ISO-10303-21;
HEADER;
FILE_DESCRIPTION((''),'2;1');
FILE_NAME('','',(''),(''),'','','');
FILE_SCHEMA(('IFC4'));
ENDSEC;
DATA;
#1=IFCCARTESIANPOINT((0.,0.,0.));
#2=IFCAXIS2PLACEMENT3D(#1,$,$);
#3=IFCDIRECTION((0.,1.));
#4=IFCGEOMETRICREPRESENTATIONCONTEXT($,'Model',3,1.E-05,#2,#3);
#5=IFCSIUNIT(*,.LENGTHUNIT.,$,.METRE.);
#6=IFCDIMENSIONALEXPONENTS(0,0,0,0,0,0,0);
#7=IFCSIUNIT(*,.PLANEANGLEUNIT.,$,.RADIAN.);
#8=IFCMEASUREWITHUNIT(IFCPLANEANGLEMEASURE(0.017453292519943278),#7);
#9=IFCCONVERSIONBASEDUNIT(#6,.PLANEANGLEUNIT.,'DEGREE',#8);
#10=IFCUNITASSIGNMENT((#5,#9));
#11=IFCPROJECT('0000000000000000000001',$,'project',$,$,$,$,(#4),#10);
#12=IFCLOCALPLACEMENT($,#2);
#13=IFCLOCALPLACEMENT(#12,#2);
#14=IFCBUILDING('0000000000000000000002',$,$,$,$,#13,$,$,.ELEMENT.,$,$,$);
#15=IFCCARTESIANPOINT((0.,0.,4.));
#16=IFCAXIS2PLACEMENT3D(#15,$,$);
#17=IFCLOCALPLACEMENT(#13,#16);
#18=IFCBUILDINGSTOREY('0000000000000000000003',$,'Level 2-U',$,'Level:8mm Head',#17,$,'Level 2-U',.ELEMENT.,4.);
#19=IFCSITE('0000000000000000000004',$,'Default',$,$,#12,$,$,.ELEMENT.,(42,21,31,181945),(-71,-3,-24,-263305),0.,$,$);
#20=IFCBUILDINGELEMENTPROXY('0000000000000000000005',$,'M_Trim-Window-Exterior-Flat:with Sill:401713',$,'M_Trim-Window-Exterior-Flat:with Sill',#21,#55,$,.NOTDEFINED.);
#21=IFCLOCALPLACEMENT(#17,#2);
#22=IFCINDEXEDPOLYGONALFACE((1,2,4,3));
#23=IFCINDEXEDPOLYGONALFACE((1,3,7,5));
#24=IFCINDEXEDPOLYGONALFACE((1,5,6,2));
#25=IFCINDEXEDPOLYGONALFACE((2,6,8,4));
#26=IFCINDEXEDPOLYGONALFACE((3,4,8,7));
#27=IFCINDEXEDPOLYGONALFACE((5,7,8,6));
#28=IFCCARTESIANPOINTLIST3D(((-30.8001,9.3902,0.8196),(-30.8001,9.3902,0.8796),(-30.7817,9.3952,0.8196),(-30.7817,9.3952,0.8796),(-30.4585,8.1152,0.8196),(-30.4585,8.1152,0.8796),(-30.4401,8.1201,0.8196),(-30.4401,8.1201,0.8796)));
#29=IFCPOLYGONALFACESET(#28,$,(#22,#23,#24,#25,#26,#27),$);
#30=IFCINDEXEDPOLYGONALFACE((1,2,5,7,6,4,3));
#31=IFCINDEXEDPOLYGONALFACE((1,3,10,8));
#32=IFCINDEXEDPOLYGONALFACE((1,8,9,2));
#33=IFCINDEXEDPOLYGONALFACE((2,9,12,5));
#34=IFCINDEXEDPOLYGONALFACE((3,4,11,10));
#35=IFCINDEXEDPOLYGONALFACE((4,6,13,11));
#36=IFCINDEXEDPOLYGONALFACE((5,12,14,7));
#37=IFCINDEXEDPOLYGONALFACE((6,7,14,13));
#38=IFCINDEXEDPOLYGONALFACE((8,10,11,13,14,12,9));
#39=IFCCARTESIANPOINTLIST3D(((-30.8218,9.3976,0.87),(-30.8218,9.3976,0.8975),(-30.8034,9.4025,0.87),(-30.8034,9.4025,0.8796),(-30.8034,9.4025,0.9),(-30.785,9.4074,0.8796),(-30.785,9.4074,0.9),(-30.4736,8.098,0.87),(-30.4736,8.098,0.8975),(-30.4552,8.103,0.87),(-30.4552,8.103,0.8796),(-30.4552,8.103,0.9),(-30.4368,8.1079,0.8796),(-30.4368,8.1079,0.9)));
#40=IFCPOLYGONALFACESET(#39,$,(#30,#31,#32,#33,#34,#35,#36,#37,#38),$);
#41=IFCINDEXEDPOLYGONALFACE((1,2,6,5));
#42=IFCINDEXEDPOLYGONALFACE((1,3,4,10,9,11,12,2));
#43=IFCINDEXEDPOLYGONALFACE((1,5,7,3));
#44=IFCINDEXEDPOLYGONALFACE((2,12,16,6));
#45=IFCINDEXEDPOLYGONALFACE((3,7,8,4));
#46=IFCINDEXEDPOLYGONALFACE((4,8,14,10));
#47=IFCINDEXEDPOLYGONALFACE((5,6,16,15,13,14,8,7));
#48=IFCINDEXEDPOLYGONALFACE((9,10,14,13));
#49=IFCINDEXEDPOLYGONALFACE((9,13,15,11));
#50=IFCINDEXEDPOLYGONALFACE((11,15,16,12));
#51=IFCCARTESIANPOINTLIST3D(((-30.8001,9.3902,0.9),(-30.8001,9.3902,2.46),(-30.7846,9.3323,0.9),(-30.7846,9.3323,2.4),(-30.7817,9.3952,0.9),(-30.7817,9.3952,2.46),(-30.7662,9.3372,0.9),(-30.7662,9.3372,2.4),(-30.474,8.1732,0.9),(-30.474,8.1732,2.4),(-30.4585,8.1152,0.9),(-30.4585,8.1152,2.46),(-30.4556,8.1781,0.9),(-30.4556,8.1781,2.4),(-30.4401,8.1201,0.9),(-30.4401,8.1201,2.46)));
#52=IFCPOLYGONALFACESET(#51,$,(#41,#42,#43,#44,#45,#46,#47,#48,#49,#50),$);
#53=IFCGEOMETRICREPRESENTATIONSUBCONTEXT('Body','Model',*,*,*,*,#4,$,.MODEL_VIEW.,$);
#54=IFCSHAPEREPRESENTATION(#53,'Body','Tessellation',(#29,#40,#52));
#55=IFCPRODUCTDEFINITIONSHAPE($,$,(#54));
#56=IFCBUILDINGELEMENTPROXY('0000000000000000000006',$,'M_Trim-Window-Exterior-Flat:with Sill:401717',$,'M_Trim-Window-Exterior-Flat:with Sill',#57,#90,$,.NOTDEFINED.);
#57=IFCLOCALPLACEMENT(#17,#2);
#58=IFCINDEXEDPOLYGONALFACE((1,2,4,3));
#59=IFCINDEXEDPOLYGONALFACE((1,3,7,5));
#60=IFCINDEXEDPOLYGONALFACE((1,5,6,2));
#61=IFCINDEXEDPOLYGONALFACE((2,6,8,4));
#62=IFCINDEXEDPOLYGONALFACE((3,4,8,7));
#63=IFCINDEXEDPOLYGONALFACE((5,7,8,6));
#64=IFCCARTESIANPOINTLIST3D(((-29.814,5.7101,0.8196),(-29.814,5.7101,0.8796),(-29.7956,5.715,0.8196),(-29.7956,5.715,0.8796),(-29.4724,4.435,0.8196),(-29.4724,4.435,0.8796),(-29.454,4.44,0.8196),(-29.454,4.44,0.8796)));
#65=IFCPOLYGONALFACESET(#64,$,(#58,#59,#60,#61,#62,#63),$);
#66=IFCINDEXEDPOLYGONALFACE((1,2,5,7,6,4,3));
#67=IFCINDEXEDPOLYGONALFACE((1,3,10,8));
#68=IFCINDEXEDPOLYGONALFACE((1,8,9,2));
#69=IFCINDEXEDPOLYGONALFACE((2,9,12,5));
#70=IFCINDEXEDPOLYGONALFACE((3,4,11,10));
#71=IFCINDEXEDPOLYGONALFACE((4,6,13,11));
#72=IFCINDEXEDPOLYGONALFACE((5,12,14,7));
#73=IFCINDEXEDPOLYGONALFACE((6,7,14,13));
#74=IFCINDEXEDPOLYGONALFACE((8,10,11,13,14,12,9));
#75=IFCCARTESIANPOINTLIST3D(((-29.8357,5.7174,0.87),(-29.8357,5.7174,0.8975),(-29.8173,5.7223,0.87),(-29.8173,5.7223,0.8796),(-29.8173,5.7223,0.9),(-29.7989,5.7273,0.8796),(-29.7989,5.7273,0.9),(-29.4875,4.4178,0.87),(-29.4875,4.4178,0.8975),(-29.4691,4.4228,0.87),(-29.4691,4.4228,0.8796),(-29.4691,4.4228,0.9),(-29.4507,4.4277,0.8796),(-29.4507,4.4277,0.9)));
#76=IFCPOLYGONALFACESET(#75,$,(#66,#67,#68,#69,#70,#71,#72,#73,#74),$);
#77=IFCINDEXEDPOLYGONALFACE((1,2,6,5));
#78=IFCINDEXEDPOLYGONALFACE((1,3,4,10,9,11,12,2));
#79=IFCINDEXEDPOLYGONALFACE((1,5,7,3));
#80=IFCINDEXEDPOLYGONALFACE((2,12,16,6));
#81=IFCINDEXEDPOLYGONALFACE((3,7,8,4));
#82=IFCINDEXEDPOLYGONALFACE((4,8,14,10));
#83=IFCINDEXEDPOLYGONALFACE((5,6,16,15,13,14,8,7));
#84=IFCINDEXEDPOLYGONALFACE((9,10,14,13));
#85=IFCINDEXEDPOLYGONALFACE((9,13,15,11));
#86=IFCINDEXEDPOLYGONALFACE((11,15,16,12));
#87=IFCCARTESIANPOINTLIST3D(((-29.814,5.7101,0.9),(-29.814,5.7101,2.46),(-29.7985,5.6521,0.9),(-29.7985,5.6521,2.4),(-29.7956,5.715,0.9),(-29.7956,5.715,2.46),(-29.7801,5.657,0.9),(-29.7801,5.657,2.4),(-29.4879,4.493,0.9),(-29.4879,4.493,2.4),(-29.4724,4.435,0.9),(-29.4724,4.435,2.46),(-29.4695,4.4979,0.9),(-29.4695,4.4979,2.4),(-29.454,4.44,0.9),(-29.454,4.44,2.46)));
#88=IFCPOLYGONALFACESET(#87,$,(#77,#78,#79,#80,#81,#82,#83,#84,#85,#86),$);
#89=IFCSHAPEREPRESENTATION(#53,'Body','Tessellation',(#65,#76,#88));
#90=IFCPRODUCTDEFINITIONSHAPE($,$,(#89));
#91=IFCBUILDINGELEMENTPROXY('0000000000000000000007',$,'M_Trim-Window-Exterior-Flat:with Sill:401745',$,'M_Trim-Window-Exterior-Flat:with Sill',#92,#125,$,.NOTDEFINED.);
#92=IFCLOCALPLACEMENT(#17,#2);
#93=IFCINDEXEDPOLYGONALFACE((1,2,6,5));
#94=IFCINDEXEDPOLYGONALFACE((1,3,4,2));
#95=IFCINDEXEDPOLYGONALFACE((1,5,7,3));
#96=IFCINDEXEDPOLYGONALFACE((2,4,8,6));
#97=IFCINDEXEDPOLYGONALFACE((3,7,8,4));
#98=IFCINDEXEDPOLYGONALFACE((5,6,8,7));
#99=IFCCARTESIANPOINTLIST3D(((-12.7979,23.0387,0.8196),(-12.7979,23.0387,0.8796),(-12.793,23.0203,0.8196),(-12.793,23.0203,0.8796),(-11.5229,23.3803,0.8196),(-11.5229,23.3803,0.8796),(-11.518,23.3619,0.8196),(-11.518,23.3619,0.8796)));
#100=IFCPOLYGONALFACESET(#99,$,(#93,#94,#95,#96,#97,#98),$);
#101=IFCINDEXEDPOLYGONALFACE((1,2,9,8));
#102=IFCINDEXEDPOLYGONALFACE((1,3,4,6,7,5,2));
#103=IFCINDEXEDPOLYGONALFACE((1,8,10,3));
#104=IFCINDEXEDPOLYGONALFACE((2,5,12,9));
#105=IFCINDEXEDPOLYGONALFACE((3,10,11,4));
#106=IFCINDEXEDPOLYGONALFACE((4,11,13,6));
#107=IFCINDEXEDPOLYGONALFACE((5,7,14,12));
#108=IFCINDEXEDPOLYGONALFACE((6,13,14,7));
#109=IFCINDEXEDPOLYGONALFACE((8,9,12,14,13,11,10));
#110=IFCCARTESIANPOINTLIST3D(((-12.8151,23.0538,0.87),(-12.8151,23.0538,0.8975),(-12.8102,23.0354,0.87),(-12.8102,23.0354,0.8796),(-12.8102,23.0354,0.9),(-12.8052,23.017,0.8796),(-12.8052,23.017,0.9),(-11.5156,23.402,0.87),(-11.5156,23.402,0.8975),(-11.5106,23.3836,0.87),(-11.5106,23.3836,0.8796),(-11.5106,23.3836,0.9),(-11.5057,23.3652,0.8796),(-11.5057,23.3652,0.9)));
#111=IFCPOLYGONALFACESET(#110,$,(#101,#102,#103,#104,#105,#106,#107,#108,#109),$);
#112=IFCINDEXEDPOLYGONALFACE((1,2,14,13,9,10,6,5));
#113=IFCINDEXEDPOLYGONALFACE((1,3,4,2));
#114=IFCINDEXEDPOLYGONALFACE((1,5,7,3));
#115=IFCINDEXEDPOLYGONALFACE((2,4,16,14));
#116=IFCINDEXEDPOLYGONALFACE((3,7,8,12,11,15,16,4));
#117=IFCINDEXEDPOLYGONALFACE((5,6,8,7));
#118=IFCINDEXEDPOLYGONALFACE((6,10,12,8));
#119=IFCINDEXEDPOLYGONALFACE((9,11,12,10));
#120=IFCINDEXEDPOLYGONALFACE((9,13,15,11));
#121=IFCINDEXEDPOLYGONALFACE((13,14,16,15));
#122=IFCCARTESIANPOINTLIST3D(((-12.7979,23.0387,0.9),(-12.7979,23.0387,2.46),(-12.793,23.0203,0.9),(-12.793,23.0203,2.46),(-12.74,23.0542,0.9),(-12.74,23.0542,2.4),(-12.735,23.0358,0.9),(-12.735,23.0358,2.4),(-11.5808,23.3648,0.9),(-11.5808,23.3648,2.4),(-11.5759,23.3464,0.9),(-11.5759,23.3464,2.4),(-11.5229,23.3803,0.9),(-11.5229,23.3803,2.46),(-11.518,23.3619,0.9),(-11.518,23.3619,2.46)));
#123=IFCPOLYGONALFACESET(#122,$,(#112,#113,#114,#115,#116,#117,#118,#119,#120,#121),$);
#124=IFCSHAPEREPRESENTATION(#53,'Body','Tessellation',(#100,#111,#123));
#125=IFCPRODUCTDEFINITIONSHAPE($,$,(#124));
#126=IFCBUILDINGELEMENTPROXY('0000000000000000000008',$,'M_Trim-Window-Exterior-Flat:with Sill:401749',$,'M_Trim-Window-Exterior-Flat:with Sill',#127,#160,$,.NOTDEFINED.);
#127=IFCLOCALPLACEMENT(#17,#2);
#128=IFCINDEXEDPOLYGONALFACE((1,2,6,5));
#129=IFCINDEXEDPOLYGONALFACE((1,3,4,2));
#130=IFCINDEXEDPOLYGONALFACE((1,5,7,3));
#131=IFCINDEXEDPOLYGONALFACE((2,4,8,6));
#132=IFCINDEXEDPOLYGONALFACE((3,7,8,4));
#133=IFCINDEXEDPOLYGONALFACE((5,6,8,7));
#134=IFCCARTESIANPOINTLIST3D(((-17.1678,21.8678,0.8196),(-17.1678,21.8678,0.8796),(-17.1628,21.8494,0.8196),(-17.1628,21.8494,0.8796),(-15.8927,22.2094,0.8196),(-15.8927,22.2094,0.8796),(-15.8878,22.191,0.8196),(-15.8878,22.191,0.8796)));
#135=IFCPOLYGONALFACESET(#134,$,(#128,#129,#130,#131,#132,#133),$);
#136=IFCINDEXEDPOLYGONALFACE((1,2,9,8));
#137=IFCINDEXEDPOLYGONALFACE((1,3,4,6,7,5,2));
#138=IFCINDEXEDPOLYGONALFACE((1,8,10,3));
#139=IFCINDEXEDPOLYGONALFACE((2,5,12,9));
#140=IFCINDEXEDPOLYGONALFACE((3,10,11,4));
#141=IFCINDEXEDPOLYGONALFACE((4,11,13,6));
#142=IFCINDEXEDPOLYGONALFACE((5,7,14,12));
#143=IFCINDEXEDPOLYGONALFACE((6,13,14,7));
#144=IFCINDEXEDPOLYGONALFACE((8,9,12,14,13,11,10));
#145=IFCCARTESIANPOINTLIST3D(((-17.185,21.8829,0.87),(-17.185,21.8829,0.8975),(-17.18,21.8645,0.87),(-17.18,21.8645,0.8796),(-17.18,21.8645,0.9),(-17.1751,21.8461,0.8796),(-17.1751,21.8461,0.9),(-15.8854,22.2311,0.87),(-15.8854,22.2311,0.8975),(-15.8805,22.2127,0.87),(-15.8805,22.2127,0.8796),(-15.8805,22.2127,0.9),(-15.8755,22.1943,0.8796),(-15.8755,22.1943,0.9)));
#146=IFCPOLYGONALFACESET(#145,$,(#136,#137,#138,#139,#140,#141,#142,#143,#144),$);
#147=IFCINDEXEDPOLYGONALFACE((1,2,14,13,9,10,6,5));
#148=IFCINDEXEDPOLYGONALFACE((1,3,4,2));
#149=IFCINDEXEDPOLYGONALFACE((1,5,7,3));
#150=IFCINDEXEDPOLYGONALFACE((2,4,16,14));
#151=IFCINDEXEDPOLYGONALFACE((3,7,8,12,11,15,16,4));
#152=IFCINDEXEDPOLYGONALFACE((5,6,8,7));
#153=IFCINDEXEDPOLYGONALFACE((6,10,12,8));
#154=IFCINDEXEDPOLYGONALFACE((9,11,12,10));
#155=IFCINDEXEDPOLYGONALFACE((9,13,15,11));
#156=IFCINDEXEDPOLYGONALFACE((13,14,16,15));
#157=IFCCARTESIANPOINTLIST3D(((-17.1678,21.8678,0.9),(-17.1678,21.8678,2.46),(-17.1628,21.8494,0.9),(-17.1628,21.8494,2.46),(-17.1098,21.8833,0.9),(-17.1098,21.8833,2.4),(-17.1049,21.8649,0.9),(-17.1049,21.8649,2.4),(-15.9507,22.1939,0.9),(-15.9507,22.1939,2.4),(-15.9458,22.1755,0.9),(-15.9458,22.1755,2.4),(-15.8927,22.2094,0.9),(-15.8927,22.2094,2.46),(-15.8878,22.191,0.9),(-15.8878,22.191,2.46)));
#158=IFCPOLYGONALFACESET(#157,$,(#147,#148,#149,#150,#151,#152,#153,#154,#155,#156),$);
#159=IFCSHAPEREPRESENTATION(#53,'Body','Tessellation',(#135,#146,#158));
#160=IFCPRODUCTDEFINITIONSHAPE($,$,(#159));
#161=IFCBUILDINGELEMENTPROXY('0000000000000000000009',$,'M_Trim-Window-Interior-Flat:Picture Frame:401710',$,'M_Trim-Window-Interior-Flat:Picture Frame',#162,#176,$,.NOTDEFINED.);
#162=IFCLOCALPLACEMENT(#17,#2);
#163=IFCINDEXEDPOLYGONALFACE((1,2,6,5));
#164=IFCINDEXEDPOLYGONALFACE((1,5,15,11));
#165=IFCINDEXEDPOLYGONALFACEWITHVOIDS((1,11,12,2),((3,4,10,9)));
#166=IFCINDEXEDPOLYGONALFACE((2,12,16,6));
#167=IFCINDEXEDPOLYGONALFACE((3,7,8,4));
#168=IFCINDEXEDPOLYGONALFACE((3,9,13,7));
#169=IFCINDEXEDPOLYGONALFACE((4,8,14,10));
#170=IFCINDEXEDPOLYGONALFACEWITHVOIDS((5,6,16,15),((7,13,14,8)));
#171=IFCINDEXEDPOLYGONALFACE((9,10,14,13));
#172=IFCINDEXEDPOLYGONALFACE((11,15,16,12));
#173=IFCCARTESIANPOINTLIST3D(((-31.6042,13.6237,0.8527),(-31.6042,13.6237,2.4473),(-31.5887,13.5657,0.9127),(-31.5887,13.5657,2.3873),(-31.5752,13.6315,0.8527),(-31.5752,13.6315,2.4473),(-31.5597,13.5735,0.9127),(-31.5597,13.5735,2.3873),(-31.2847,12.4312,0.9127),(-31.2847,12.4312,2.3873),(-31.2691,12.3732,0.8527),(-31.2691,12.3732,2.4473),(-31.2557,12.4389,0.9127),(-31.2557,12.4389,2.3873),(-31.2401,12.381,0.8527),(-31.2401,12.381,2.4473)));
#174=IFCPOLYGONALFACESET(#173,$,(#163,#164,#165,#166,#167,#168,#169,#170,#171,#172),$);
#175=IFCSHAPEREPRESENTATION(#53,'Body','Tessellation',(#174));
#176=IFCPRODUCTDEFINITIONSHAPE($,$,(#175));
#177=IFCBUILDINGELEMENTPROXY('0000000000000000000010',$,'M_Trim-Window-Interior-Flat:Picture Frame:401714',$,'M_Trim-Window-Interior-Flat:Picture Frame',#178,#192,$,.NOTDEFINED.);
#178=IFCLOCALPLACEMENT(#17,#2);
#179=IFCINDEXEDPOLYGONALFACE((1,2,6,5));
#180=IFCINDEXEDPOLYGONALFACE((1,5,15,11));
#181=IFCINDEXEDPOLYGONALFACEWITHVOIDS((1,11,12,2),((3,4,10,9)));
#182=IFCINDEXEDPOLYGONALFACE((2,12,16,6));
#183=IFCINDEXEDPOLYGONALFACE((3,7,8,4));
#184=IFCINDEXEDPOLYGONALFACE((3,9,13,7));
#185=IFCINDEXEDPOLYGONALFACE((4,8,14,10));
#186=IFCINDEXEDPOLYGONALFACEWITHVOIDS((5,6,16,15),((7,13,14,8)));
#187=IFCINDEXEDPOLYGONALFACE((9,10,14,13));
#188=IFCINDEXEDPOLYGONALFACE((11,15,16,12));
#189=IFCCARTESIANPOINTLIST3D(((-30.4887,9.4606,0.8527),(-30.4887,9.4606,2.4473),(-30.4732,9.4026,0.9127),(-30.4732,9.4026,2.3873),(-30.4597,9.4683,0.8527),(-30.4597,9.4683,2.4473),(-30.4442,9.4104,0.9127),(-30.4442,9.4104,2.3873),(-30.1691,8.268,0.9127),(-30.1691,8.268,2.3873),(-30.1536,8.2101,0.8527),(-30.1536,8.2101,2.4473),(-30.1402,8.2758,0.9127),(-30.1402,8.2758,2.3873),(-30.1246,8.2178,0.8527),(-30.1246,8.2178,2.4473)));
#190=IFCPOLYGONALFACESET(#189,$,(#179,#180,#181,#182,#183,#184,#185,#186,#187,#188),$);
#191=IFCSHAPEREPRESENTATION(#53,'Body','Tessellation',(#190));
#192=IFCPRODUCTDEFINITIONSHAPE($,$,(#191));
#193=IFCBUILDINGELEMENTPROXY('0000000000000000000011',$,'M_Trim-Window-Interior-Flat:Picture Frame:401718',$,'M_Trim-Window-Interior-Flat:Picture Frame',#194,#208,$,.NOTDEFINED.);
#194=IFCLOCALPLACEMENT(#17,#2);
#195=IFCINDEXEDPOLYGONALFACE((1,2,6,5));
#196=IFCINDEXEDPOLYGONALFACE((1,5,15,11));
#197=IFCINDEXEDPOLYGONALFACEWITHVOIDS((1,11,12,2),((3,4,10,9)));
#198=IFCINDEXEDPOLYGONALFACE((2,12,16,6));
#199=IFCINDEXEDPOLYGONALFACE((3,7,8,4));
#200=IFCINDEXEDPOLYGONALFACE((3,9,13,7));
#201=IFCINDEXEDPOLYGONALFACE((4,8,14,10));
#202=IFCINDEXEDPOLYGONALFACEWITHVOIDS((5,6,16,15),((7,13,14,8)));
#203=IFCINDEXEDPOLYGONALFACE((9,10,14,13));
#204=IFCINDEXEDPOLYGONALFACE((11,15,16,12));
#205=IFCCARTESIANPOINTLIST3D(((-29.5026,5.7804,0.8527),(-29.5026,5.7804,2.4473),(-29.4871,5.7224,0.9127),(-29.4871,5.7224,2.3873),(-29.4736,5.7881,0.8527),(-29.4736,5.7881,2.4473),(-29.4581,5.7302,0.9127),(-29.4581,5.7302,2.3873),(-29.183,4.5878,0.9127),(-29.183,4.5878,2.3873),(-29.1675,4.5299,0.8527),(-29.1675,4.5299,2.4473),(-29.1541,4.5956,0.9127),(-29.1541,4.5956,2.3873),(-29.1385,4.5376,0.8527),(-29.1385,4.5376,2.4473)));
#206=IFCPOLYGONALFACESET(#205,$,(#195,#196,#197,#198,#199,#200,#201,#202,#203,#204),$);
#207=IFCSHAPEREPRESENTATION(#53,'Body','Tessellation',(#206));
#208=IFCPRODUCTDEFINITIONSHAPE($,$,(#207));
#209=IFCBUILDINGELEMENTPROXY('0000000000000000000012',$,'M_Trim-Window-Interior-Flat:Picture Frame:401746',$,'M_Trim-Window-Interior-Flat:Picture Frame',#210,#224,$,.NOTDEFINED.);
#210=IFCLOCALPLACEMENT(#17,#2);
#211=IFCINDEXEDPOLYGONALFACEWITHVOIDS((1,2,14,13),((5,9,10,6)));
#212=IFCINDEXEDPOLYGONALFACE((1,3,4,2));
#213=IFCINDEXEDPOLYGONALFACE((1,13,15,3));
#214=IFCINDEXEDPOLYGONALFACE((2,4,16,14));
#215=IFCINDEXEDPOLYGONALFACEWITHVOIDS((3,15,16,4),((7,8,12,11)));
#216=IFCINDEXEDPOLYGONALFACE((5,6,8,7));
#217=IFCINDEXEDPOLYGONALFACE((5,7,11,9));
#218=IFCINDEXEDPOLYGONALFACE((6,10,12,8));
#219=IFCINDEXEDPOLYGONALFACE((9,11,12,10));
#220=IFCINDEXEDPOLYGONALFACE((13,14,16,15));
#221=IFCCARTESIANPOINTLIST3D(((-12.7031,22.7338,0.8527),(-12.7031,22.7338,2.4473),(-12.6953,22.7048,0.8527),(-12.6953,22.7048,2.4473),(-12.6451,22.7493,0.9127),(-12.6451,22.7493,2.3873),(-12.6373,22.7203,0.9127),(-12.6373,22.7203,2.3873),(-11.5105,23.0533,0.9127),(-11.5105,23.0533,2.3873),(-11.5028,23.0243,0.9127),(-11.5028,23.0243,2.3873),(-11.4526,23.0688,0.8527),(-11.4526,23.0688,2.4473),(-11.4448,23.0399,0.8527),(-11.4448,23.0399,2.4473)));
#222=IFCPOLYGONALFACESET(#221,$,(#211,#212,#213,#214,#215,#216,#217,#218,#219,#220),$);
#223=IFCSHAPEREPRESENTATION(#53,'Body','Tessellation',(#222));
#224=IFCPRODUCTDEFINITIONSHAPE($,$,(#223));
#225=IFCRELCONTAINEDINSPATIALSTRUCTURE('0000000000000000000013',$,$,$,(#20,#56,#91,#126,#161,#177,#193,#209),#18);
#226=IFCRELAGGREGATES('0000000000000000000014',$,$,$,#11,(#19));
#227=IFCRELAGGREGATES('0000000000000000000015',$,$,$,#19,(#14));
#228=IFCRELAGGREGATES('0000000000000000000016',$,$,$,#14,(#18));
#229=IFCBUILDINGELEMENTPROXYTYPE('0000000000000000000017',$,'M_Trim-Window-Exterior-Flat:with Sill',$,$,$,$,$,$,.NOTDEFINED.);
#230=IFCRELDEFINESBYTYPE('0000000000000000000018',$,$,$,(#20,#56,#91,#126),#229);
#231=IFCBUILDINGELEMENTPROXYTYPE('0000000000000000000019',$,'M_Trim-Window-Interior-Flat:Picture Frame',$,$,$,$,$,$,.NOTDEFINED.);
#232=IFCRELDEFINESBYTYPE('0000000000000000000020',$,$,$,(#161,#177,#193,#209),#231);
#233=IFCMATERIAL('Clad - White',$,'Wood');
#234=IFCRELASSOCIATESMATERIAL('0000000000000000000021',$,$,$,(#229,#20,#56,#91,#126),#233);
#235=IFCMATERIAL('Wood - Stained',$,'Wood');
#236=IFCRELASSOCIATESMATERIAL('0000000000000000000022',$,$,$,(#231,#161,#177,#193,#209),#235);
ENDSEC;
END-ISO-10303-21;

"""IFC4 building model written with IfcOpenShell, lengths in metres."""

from ifc_helpers import new_model, entity, si_unit, converted_unit, direction, frame, frame_2d, origin, place, context, subcontext, project, spatial, polyline, rectangle, outline, extrude, source, transform, mapped, material, type_object, type_shapes, element, save


model = new_model("IFC4")

# Units and contexts
model_context = context("Model", 3, precision=1e-05, world=origin(), true_north=direction((0.0, 1.0)))
body_context = subcontext(model_context, "Body", "Model", "MODEL_VIEW")
ifc_project = project(units=[si_unit("LENGTHUNIT", "METRE"), converted_unit("PLANEANGLEUNIT", "DEGREE", entity("IfcPlaneAngleMeasure", 0.017453292519943278), si_unit("PLANEANGLEUNIT", "RADIAN"), dimensions=[0, 0, 0, 0, 0, 0, 0])], contexts=[model_context])

# Site, building, storey
site_placement = place(None, origin())
site = spatial("IfcSite", under=ifc_project, at=site_placement, Name="Default", CompositionType="ELEMENT", RefLatitude=(42, 21, 31, 181945), RefLongitude=(-71, -3, -24, -263305), RefElevation=0.0)
building_placement = place(site_placement, origin())
building = spatial("IfcBuilding", under=site, at=building_placement, CompositionType="ELEMENT")
storey_placement = place(building_placement, frame((0.0, 0.0, 4.0)))
storey = spatial("IfcBuildingStorey", under=building, at=storey_placement, Name="Level 2-U", ObjectType="Level:8mm Head", LongName="Level 2-U", CompositionType="ELEMENT", Elevation=4.0)

# Building element proxies
ifc_material_1 = material(Name="Clad - White", Category="Wood")
ifc_material_2 = material(Name="Wood - Stained", Category="Wood")
building_element_proxy_type_1 = type_object("IfcBuildingElementProxyType", Name="M_Trim-Window-Exterior-Flat:with Sill", PredefinedType="NOTDEFINED", material=ifc_material_1)
shared_shape_1 = source(origin(), body_context, "Body", "SweptSolid", [
    extrude(rectangle(XDim=1.32, YDim=0.06, at=frame_2d((0.0, 0.0), x_axis=(1.0, 0.0))), frame((0.0, -1.5504, 0.0), z_axis=(0.0, 0.0, 1.0), x_axis=(-1.0, 0.0, 0.0)), (0.0, 0.0, 1.0), 0.019),
    extrude(outline(polyline([(-0.019, -0.0152), (0.0, -0.0152), (0.0, -0.0057), (0.019, -0.0057), (0.019, 0.0148), (0.0, 0.0148), (-0.019, 0.0123), (-0.019, -0.0152)])), frame((-0.6727, -1.5148, 0.019), z_axis=(1.0, 0.0, 0.0), x_axis=(0.0, 0.0, -1.0)), (0.0, 0.0, 1.0), 1.3454),
    extrude(outline(polyline([(-0.795, -0.66), (0.765, -0.66), (0.765, -0.6), (-0.735, -0.6), (-0.735, 0.6), (0.765, 0.6), (0.765, 0.66), (-0.795, 0.66), (-0.795, -0.66)])), frame((0.0, -0.735, 0.0), z_axis=(0.0, 0.0, 1.0), x_axis=(0.0, -1.0, 0.0)), (0.0, 0.0, 1.0), 0.019),
])
type_shapes(building_element_proxy_type_1, [shared_shape_1])
for number, where, z_axis, x_axis, name in (
    (1, (-30.6109, 8.7577, 2.4), (-0.965926, -0.258819, 0.0), (0.258819, -0.965926, 0.0), "M_Trim-Window-Exterior-Flat:with Sill:401713"),
    (2, (-29.6248, 5.0775, 2.4), (-0.965926, -0.258819, 0.0), (0.258819, -0.965926, 0.0), "M_Trim-Window-Exterior-Flat:with Sill:401717"),
    (3, (-12.1555, 23.1911, 2.4), (-0.258819, 0.965926, 0.0), (-0.965926, -0.258819, 0.0), "M_Trim-Window-Exterior-Flat:with Sill:401745"),
    (4, (-16.5253, 22.0202, 2.4), (-0.258819, 0.965926, 0.0), (-0.965926, -0.258819, 0.0), "M_Trim-Window-Exterior-Flat:with Sill:401749"),
):
    element("IfcBuildingElementProxy", number, at=place(storey_placement, frame(where, z_axis=z_axis, x_axis=x_axis)), inside=storey, type_object=building_element_proxy_type_1, material=ifc_material_1, Name=name, ObjectType="M_Trim-Window-Exterior-Flat:with Sill", PredefinedType="NOTDEFINED", context=body_context, shape_type="MappedRepresentation", body=[
        mapped(shared_shape_1, transform((0.0, 0.0, 0.0), scale=1.0)),
    ])
building_element_proxy_type_2 = type_object("IfcBuildingElementProxyType", Name="M_Trim-Window-Interior-Flat:Picture Frame", PredefinedType="NOTDEFINED", material=ifc_material_2)
shared_shape_2 = source(origin(), body_context, "Body", "SweptSolid", [
    extrude(outline(polyline([(-0.6473, -0.7973), (0.6473, -0.7973), (0.6473, 0.7973), (-0.6473, 0.7973), (-0.6473, -0.7973)]), holes=[polyline([(-0.5873, -0.7373), (-0.5873, 0.7373), (0.5873, 0.7373), (0.5873, -0.7373), (-0.5873, -0.7373)])]), frame((0.0, -0.75, 0.0), z_axis=(0.0, 0.0, 1.0), x_axis=(-1.0, 0.0, 0.0)), (0.0, 0.0, 1.0), 0.03),
])
type_shapes(building_element_proxy_type_2, [shared_shape_2])
for number, where, z_axis, x_axis, name in (
    (5, (-31.4367, 12.9984, 2.4), (0.965926, 0.258819, 0.0), (-0.258819, 0.965926, 0.0), "M_Trim-Window-Interior-Flat:Picture Frame:401710"),
    (6, (-30.3211, 8.8353, 2.4), (0.965926, 0.258819, 0.0), (-0.258819, 0.965926, 0.0), "M_Trim-Window-Interior-Flat:Picture Frame:401714"),
    (7, (-29.335, 5.1551, 2.4), (0.965926, 0.258819, 0.0), (-0.258819, 0.965926, 0.0), "M_Trim-Window-Interior-Flat:Picture Frame:401718"),
    (8, (-12.0778, 22.9013, 2.4), (0.258819, -0.965926, 0.0), (0.965926, 0.258819, 0.0), "M_Trim-Window-Interior-Flat:Picture Frame:401746"),
):
    element("IfcBuildingElementProxy", number, at=place(storey_placement, frame(where, z_axis=z_axis, x_axis=x_axis)), inside=storey, type_object=building_element_proxy_type_2, material=ifc_material_2, Name=name, ObjectType="M_Trim-Window-Interior-Flat:Picture Frame", PredefinedType="NOTDEFINED", context=body_context, shape_type="MappedRepresentation", body=[
        mapped(shared_shape_2, transform((0.0, 0.0, 0.0), scale=1.0)),
    ])

save(model, "model.ifc")
